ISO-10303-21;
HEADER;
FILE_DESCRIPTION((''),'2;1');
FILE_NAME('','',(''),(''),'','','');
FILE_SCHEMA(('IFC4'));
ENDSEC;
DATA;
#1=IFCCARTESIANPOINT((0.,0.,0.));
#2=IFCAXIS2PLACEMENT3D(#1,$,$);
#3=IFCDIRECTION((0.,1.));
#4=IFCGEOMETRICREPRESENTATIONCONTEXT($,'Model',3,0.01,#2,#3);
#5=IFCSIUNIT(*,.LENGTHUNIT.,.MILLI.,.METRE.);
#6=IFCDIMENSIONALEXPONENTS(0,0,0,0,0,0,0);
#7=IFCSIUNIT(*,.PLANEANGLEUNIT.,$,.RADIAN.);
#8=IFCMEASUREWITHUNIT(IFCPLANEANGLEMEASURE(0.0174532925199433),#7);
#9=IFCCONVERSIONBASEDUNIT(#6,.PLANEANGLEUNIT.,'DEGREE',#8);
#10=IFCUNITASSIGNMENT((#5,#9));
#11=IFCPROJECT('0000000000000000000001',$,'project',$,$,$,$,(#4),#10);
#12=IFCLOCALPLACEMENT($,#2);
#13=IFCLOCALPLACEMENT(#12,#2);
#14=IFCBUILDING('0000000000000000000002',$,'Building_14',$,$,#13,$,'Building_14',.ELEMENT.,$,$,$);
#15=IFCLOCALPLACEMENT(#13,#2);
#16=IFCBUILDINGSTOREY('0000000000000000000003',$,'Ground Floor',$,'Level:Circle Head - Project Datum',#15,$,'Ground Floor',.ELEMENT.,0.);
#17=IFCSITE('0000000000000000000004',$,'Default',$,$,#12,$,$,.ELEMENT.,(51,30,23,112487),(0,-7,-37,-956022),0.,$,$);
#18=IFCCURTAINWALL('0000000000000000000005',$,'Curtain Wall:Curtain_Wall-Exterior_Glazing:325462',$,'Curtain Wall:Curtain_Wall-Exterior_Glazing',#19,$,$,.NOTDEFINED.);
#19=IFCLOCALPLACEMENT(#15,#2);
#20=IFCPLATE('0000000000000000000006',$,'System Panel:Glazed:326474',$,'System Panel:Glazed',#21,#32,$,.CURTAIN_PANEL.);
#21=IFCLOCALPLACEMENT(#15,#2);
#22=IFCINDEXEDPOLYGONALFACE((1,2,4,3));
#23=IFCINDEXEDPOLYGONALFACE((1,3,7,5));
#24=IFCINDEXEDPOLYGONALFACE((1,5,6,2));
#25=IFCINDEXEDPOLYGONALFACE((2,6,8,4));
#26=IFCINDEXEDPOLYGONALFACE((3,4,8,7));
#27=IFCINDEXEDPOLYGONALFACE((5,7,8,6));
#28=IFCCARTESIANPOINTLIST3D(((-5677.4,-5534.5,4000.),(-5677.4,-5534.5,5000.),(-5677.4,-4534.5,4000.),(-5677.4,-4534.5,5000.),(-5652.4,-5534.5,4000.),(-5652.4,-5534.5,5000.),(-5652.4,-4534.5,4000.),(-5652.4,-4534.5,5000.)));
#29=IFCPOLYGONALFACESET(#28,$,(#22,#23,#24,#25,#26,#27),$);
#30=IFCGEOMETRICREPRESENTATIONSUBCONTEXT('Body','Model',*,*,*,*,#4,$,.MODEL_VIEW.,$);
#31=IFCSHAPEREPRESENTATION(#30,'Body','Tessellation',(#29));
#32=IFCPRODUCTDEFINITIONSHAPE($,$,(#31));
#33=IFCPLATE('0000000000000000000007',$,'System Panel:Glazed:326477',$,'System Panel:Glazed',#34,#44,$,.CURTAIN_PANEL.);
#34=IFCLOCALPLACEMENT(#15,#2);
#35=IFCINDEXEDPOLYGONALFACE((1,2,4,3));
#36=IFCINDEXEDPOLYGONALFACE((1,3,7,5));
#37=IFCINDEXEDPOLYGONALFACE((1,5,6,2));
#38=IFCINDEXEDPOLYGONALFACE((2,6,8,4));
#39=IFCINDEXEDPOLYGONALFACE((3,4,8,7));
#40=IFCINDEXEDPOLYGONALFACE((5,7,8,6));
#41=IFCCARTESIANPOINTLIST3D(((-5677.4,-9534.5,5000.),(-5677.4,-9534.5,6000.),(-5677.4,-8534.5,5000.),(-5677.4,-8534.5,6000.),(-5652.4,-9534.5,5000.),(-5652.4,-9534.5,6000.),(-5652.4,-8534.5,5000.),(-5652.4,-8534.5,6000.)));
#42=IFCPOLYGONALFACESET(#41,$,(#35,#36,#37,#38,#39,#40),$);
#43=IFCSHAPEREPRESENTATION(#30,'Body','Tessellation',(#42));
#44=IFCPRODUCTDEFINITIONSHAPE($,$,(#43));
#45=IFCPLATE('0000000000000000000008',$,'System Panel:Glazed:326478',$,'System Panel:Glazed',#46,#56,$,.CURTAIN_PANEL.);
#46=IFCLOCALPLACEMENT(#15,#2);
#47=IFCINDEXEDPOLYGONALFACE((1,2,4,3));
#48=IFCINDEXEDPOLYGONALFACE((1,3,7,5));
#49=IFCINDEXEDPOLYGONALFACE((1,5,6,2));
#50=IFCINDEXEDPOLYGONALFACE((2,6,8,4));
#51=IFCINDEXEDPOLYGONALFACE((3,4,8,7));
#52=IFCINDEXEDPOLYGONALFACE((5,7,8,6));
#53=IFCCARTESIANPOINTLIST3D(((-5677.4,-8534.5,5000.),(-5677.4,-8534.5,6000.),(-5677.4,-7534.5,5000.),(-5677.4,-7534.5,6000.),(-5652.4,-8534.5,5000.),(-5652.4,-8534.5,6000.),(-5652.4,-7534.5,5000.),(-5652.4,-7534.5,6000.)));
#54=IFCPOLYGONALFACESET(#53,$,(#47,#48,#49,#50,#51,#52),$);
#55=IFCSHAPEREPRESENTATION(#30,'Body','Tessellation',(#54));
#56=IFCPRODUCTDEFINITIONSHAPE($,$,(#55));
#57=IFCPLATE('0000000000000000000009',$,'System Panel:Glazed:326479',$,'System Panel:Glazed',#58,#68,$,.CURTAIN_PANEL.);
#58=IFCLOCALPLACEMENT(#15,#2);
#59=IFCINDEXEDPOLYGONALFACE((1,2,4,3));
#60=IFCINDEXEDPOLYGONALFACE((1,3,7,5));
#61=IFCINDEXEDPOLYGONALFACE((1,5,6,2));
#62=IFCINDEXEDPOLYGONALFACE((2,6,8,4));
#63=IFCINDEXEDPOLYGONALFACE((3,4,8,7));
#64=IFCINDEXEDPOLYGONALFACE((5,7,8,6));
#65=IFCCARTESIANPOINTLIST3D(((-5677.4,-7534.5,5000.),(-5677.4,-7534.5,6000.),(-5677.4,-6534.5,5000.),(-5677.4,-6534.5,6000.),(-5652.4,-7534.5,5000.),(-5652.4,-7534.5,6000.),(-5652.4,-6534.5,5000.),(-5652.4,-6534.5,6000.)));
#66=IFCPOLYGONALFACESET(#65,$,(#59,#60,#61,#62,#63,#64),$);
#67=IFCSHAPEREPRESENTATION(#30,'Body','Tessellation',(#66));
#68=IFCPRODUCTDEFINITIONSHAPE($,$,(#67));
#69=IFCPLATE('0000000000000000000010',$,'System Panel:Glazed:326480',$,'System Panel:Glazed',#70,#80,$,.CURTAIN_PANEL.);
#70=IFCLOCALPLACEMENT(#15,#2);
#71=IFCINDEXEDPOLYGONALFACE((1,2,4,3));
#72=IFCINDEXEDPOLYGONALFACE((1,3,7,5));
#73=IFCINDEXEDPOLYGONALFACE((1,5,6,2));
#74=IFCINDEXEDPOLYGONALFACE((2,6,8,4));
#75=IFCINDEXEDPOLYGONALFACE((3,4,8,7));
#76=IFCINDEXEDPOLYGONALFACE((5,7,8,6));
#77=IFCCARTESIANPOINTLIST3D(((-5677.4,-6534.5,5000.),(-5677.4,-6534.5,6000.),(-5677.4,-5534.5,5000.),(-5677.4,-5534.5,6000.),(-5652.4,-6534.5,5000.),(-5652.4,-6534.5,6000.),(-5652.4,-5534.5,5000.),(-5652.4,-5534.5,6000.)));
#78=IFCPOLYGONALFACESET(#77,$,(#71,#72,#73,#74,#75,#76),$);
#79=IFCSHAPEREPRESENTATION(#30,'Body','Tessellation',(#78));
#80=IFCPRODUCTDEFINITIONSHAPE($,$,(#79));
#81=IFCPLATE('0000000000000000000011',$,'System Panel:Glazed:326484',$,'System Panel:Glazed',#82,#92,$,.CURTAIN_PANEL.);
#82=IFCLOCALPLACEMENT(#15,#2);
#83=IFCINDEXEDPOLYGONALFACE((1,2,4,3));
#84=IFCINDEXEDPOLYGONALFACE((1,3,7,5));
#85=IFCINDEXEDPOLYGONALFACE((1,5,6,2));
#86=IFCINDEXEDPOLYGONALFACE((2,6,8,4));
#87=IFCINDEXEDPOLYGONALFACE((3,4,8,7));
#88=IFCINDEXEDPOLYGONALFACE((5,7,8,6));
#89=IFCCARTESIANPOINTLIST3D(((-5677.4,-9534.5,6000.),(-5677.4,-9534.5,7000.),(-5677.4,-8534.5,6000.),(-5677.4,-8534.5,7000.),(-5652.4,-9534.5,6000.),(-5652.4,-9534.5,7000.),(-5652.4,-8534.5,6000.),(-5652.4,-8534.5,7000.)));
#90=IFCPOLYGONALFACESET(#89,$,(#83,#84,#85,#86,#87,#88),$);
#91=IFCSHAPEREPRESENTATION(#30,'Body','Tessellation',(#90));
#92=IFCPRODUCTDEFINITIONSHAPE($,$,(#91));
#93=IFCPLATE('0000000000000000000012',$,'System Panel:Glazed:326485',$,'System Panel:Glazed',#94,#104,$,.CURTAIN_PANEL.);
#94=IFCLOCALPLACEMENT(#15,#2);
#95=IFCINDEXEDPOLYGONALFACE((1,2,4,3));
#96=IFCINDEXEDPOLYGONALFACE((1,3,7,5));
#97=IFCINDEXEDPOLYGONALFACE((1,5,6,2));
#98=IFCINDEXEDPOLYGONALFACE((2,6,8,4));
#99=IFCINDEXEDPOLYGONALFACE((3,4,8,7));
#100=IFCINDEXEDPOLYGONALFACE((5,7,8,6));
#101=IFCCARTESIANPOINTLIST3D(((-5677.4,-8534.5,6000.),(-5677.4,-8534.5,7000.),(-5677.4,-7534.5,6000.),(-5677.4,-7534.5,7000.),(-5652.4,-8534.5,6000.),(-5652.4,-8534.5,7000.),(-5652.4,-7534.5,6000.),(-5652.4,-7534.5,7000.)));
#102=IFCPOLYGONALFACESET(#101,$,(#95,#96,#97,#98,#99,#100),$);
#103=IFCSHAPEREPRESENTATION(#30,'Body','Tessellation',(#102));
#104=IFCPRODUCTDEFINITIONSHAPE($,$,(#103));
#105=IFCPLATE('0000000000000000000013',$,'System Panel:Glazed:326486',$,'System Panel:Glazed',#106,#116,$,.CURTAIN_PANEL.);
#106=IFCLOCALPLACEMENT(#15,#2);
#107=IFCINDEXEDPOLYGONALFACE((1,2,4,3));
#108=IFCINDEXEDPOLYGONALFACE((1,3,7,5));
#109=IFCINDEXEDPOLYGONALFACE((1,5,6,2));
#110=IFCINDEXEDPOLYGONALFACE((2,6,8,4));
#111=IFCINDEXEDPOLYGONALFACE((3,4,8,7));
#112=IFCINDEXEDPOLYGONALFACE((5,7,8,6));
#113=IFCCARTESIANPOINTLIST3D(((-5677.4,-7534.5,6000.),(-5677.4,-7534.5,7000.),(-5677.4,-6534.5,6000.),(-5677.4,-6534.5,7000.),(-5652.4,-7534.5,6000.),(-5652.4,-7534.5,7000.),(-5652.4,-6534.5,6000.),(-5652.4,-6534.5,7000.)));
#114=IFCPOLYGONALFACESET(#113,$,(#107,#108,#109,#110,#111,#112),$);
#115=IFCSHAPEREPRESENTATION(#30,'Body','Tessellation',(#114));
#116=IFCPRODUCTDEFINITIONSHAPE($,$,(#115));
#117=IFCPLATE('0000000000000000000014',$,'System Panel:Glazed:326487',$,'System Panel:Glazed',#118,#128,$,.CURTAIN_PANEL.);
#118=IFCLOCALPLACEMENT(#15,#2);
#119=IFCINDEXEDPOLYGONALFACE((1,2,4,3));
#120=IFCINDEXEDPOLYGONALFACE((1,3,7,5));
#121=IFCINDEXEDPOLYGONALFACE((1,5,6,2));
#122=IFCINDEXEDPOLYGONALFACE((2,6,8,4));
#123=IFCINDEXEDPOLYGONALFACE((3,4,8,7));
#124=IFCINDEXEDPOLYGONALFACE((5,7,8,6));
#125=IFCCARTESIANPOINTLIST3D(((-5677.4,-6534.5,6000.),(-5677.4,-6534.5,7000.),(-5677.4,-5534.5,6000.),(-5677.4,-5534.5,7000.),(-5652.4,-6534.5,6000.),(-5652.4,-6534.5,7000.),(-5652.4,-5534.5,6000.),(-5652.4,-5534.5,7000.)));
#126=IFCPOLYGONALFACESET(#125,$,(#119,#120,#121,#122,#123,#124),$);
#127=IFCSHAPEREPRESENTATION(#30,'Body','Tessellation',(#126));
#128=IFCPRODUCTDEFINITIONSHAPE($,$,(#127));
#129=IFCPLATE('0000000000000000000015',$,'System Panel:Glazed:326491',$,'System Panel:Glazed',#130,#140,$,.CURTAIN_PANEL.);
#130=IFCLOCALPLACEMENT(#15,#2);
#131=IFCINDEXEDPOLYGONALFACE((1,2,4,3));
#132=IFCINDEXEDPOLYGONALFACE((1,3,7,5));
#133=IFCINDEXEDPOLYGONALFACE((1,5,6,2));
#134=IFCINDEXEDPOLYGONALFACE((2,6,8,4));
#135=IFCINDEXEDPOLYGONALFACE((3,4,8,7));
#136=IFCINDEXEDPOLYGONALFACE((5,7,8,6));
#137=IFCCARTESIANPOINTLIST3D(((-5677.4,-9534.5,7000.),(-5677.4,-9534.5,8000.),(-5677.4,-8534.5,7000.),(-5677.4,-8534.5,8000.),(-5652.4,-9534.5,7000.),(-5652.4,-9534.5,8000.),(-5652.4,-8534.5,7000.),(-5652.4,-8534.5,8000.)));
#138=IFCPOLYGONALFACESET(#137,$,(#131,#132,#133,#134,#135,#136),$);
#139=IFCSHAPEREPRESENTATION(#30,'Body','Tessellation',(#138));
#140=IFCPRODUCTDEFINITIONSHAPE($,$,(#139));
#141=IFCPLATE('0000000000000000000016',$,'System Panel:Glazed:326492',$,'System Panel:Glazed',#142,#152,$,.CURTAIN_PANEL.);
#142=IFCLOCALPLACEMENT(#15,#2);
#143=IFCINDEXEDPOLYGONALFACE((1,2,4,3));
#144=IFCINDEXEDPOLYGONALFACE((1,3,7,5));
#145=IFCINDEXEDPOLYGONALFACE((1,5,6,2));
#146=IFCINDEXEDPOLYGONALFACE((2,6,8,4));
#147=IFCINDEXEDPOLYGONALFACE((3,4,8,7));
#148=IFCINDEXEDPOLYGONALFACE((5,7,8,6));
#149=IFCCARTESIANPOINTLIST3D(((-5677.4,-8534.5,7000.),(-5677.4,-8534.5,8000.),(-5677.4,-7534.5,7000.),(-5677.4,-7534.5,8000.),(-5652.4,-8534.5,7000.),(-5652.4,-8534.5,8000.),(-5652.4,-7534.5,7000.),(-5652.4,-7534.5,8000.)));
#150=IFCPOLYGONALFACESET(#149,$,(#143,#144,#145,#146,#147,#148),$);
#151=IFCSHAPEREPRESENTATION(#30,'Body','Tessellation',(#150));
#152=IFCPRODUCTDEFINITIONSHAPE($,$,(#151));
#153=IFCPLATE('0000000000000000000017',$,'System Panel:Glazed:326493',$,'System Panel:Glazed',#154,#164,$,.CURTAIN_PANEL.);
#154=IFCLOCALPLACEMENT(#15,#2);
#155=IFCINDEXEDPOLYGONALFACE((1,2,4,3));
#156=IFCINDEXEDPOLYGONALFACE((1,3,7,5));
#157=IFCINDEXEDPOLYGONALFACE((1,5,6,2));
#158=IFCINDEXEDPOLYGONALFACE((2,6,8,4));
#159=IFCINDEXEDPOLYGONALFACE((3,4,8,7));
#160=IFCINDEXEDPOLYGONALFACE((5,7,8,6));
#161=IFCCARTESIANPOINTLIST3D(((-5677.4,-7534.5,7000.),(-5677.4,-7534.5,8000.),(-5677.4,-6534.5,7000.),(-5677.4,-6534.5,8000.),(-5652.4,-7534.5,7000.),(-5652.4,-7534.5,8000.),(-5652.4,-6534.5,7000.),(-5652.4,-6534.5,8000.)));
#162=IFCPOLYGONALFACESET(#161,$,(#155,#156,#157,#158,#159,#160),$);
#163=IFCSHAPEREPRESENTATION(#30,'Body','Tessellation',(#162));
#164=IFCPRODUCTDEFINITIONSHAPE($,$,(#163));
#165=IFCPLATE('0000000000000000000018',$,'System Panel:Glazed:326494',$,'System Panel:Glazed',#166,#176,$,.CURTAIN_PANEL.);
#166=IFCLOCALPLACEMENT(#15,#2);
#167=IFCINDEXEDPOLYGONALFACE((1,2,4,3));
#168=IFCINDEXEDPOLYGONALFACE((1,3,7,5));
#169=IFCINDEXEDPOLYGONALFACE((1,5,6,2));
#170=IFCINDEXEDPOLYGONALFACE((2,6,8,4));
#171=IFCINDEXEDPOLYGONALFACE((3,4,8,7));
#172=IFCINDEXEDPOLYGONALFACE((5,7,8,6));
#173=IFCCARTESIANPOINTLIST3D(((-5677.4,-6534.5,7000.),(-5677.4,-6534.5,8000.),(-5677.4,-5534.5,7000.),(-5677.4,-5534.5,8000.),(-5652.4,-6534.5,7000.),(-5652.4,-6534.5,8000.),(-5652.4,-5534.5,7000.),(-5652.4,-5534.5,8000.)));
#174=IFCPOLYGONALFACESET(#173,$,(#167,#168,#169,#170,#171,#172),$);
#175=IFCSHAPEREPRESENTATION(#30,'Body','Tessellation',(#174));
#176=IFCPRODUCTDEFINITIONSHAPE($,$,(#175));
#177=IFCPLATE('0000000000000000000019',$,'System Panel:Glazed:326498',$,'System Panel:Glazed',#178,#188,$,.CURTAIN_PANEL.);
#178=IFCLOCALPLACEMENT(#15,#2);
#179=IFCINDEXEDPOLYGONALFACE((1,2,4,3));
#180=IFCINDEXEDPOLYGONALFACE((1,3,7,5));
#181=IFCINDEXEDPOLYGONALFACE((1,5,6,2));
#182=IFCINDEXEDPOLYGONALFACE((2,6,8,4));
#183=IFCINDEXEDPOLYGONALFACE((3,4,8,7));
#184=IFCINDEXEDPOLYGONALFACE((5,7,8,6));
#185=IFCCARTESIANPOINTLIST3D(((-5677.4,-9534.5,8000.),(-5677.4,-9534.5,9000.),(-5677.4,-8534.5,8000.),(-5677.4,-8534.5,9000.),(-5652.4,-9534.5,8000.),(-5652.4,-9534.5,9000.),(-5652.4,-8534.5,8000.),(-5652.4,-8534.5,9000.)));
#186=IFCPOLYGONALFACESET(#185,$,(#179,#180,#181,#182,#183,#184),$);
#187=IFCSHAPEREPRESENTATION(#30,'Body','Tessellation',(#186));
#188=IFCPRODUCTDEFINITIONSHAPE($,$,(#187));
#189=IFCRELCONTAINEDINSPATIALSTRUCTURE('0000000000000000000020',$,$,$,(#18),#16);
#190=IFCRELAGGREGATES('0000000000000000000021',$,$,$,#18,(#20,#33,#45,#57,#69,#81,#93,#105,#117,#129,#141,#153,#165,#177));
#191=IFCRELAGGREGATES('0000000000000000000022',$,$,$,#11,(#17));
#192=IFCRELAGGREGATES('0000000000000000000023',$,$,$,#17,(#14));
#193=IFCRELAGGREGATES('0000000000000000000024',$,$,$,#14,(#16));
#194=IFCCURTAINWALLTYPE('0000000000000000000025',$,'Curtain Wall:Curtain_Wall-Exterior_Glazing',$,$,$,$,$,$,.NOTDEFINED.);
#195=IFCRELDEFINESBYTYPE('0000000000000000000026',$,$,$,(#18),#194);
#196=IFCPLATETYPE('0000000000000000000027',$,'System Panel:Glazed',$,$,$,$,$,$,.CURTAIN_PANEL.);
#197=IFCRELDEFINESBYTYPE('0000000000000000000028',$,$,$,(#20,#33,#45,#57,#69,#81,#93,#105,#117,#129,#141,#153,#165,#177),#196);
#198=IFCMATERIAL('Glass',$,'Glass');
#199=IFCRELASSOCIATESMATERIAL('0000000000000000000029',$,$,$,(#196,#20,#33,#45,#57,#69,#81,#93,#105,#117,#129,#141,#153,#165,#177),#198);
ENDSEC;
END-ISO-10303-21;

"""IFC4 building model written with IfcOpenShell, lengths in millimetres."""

from ifc_helpers import new_model, entity, si_unit, converted_unit, direction, frame, origin, place, context, subcontext, project, spatial, indexed_curve, outline, extrude, source, transform, mapped, material, type_object, type_shapes, element, aggregate, save


model = new_model("IFC4")

# Units and contexts
model_context = context("Model", 3, precision=0.01, world=origin(), true_north=direction((0.0, 1.0)))
body_context = subcontext(model_context, "Body", "Model", "MODEL_VIEW")
ifc_project = project(units=[si_unit("LENGTHUNIT", "METRE", prefix="MILLI"), converted_unit("PLANEANGLEUNIT", "DEGREE", entity("IfcPlaneAngleMeasure", 0.0174532925199433), si_unit("PLANEANGLEUNIT", "RADIAN"), dimensions=[0, 0, 0, 0, 0, 0, 0])], contexts=[model_context])

# Site, building, storey
site_placement = place(None, origin())
site = spatial("IfcSite", under=ifc_project, at=site_placement, Name="Default", CompositionType="ELEMENT", RefLatitude=(51, 30, 23, 112487), RefLongitude=(0, -7, -37, -956022), RefElevation=0.0)
building_placement = place(site_placement, origin())
building = spatial("IfcBuilding", under=site, at=building_placement, Name="Building_14", LongName="Building_14", CompositionType="ELEMENT")
storey_placement = place(building_placement, origin())
storey = spatial("IfcBuildingStorey", under=building, at=storey_placement, Name="Ground Floor", ObjectType="Level:Circle Head - Project Datum", LongName="Ground Floor", CompositionType="ELEMENT", Elevation=0.0)

# Curtain wall, plates
curtain_wall_type = type_object("IfcCurtainWallType", Name="Curtain Wall:Curtain_Wall-Exterior_Glazing", PredefinedType="NOTDEFINED")
curtain_wall_1_placement = place(storey_placement, origin())
curtain_wall_1 = element("IfcCurtainWall", 1, at=curtain_wall_1_placement, inside=storey, type_object=curtain_wall_type, Name="Curtain Wall:Curtain_Wall-Exterior_Glazing:325462", ObjectType="Curtain Wall:Curtain_Wall-Exterior_Glazing", PredefinedType="NOTDEFINED")
ifc_material = material(Name="Glass", Category="Glass")
plate_type = type_object("IfcPlateType", Name="System Panel:Glazed", PredefinedType="CURTAIN_PANEL", material=ifc_material)
shared_shape = source(origin(), body_context, "Body", "SweptSolid", [
    extrude(outline(indexed_curve([(-12.5, -500.0), (12.5, -500.0), (12.5, 500.0), (-12.5, 500.0), (-12.5, -500.0)], self_intersect=False)), frame((0.0, -37.0, 0.0), z_axis=(0.0, 0.0, 1.0), x_axis=(0.0, 1.0, 0.0)), (0.0, 0.0, 1.0), 1000.0),
])
type_shapes(plate_type, [shared_shape])
plate_1_placement = place(curtain_wall_1_placement, frame((-5701.9, -5034.5, 4000.0), z_axis=(0.0, 0.0, 1.0), x_axis=(0.0, 1.0, 0.0)))
plate_1 = element("IfcPlate", 2, at=plate_1_placement, type_object=plate_type, material=ifc_material, Name="System Panel:Glazed:326474", ObjectType="System Panel:Glazed", PredefinedType="CURTAIN_PANEL", context=body_context, shape_type="MappedRepresentation", body=[
    mapped(shared_shape, transform((0.0, 0.0, 0.0), scale=1.0)),
])
plate_2_placement = place(curtain_wall_1_placement, frame((-5701.9, -9034.5, 5000.0), z_axis=(0.0, 0.0, 1.0), x_axis=(0.0, 1.0, 0.0)))
plate_2 = element("IfcPlate", 3, at=plate_2_placement, type_object=plate_type, material=ifc_material, Name="System Panel:Glazed:326477", ObjectType="System Panel:Glazed", PredefinedType="CURTAIN_PANEL", context=body_context, shape_type="MappedRepresentation", body=[
    mapped(shared_shape, transform((0.0, 0.0, 0.0), scale=1.0)),
])
plate_3_placement = place(curtain_wall_1_placement, frame((-5701.9, -8034.5, 5000.0), z_axis=(0.0, 0.0, 1.0), x_axis=(0.0, 1.0, 0.0)))
plate_3 = element("IfcPlate", 4, at=plate_3_placement, type_object=plate_type, material=ifc_material, Name="System Panel:Glazed:326478", ObjectType="System Panel:Glazed", PredefinedType="CURTAIN_PANEL", context=body_context, shape_type="MappedRepresentation", body=[
    mapped(shared_shape, transform((0.0, 0.0, 0.0), scale=1.0)),
])
plate_4_placement = place(curtain_wall_1_placement, frame((-5701.9, -7034.5, 5000.0), z_axis=(0.0, 0.0, 1.0), x_axis=(0.0, 1.0, 0.0)))
plate_4 = element("IfcPlate", 5, at=plate_4_placement, type_object=plate_type, material=ifc_material, Name="System Panel:Glazed:326479", ObjectType="System Panel:Glazed", PredefinedType="CURTAIN_PANEL", context=body_context, shape_type="MappedRepresentation", body=[
    mapped(shared_shape, transform((0.0, 0.0, 0.0), scale=1.0)),
])
plate_5_placement = place(curtain_wall_1_placement, frame((-5701.9, -6034.5, 5000.0), z_axis=(0.0, 0.0, 1.0), x_axis=(0.0, 1.0, 0.0)))
plate_5 = element("IfcPlate", 6, at=plate_5_placement, type_object=plate_type, material=ifc_material, Name="System Panel:Glazed:326480", ObjectType="System Panel:Glazed", PredefinedType="CURTAIN_PANEL", context=body_context, shape_type="MappedRepresentation", body=[
    mapped(shared_shape, transform((0.0, 0.0, 0.0), scale=1.0)),
])
plate_6_placement = place(curtain_wall_1_placement, frame((-5701.9, -9034.5, 6000.0), z_axis=(0.0, 0.0, 1.0), x_axis=(0.0, 1.0, 0.0)))
plate_6 = element("IfcPlate", 7, at=plate_6_placement, type_object=plate_type, material=ifc_material, Name="System Panel:Glazed:326484", ObjectType="System Panel:Glazed", PredefinedType="CURTAIN_PANEL", context=body_context, shape_type="MappedRepresentation", body=[
    mapped(shared_shape, transform((0.0, 0.0, 0.0), scale=1.0)),
])
plate_7_placement = place(curtain_wall_1_placement, frame((-5701.9, -8034.5, 6000.0), z_axis=(0.0, 0.0, 1.0), x_axis=(0.0, 1.0, 0.0)))
plate_7 = element("IfcPlate", 8, at=plate_7_placement, type_object=plate_type, material=ifc_material, Name="System Panel:Glazed:326485", ObjectType="System Panel:Glazed", PredefinedType="CURTAIN_PANEL", context=body_context, shape_type="MappedRepresentation", body=[
    mapped(shared_shape, transform((0.0, 0.0, 0.0), scale=1.0)),
])
plate_8_placement = place(curtain_wall_1_placement, frame((-5701.9, -7034.5, 6000.0), z_axis=(0.0, 0.0, 1.0), x_axis=(0.0, 1.0, 0.0)))
plate_8 = element("IfcPlate", 9, at=plate_8_placement, type_object=plate_type, material=ifc_material, Name="System Panel:Glazed:326486", ObjectType="System Panel:Glazed", PredefinedType="CURTAIN_PANEL", context=body_context, shape_type="MappedRepresentation", body=[
    mapped(shared_shape, transform((0.0, 0.0, 0.0), scale=1.0)),
])
plate_9_placement = place(curtain_wall_1_placement, frame((-5701.9, -6034.5, 6000.0), z_axis=(0.0, 0.0, 1.0), x_axis=(0.0, 1.0, 0.0)))
plate_9 = element("IfcPlate", 10, at=plate_9_placement, type_object=plate_type, material=ifc_material, Name="System Panel:Glazed:326487", ObjectType="System Panel:Glazed", PredefinedType="CURTAIN_PANEL", context=body_context, shape_type="MappedRepresentation", body=[
    mapped(shared_shape, transform((0.0, 0.0, 0.0), scale=1.0)),
])
plate_10_placement = place(curtain_wall_1_placement, frame((-5701.9, -9034.5, 7000.0), z_axis=(0.0, 0.0, 1.0), x_axis=(0.0, 1.0, 0.0)))
plate_10 = element("IfcPlate", 11, at=plate_10_placement, type_object=plate_type, material=ifc_material, Name="System Panel:Glazed:326491", ObjectType="System Panel:Glazed", PredefinedType="CURTAIN_PANEL", context=body_context, shape_type="MappedRepresentation", body=[
    mapped(shared_shape, transform((0.0, 0.0, 0.0), scale=1.0)),
])
plate_11_placement = place(curtain_wall_1_placement, frame((-5701.9, -8034.5, 7000.0), z_axis=(0.0, 0.0, 1.0), x_axis=(0.0, 1.0, 0.0)))
plate_11 = element("IfcPlate", 12, at=plate_11_placement, type_object=plate_type, material=ifc_material, Name="System Panel:Glazed:326492", ObjectType="System Panel:Glazed", PredefinedType="CURTAIN_PANEL", context=body_context, shape_type="MappedRepresentation", body=[
    mapped(shared_shape, transform((0.0, 0.0, 0.0), scale=1.0)),
])
plate_12_placement = place(curtain_wall_1_placement, frame((-5701.9, -7034.5, 7000.0), z_axis=(0.0, 0.0, 1.0), x_axis=(0.0, 1.0, 0.0)))
plate_12 = element("IfcPlate", 13, at=plate_12_placement, type_object=plate_type, material=ifc_material, Name="System Panel:Glazed:326493", ObjectType="System Panel:Glazed", PredefinedType="CURTAIN_PANEL", context=body_context, shape_type="MappedRepresentation", body=[
    mapped(shared_shape, transform((0.0, 0.0, 0.0), scale=1.0)),
])
plate_13_placement = place(curtain_wall_1_placement, frame((-5701.9, -6034.5, 7000.0), z_axis=(0.0, 0.0, 1.0), x_axis=(0.0, 1.0, 0.0)))
plate_13 = element("IfcPlate", 14, at=plate_13_placement, type_object=plate_type, material=ifc_material, Name="System Panel:Glazed:326494", ObjectType="System Panel:Glazed", PredefinedType="CURTAIN_PANEL", context=body_context, shape_type="MappedRepresentation", body=[
    mapped(shared_shape, transform((0.0, 0.0, 0.0), scale=1.0)),
])
plate_14_placement = place(curtain_wall_1_placement, frame((-5701.9, -9034.5, 8000.0), z_axis=(0.0, 0.0, 1.0), x_axis=(0.0, 1.0, 0.0)))
plate_14 = element("IfcPlate", 15, at=plate_14_placement, type_object=plate_type, material=ifc_material, Name="System Panel:Glazed:326498", ObjectType="System Panel:Glazed", PredefinedType="CURTAIN_PANEL", context=body_context, shape_type="MappedRepresentation", body=[
    mapped(shared_shape, transform((0.0, 0.0, 0.0), scale=1.0)),
])
aggregate(curtain_wall_1, [plate_1, plate_2, plate_3, plate_4, plate_5, plate_6, plate_7, plate_8, plate_9, plate_10, plate_11, plate_12, plate_13, plate_14])

save(model, "model.ifc")
